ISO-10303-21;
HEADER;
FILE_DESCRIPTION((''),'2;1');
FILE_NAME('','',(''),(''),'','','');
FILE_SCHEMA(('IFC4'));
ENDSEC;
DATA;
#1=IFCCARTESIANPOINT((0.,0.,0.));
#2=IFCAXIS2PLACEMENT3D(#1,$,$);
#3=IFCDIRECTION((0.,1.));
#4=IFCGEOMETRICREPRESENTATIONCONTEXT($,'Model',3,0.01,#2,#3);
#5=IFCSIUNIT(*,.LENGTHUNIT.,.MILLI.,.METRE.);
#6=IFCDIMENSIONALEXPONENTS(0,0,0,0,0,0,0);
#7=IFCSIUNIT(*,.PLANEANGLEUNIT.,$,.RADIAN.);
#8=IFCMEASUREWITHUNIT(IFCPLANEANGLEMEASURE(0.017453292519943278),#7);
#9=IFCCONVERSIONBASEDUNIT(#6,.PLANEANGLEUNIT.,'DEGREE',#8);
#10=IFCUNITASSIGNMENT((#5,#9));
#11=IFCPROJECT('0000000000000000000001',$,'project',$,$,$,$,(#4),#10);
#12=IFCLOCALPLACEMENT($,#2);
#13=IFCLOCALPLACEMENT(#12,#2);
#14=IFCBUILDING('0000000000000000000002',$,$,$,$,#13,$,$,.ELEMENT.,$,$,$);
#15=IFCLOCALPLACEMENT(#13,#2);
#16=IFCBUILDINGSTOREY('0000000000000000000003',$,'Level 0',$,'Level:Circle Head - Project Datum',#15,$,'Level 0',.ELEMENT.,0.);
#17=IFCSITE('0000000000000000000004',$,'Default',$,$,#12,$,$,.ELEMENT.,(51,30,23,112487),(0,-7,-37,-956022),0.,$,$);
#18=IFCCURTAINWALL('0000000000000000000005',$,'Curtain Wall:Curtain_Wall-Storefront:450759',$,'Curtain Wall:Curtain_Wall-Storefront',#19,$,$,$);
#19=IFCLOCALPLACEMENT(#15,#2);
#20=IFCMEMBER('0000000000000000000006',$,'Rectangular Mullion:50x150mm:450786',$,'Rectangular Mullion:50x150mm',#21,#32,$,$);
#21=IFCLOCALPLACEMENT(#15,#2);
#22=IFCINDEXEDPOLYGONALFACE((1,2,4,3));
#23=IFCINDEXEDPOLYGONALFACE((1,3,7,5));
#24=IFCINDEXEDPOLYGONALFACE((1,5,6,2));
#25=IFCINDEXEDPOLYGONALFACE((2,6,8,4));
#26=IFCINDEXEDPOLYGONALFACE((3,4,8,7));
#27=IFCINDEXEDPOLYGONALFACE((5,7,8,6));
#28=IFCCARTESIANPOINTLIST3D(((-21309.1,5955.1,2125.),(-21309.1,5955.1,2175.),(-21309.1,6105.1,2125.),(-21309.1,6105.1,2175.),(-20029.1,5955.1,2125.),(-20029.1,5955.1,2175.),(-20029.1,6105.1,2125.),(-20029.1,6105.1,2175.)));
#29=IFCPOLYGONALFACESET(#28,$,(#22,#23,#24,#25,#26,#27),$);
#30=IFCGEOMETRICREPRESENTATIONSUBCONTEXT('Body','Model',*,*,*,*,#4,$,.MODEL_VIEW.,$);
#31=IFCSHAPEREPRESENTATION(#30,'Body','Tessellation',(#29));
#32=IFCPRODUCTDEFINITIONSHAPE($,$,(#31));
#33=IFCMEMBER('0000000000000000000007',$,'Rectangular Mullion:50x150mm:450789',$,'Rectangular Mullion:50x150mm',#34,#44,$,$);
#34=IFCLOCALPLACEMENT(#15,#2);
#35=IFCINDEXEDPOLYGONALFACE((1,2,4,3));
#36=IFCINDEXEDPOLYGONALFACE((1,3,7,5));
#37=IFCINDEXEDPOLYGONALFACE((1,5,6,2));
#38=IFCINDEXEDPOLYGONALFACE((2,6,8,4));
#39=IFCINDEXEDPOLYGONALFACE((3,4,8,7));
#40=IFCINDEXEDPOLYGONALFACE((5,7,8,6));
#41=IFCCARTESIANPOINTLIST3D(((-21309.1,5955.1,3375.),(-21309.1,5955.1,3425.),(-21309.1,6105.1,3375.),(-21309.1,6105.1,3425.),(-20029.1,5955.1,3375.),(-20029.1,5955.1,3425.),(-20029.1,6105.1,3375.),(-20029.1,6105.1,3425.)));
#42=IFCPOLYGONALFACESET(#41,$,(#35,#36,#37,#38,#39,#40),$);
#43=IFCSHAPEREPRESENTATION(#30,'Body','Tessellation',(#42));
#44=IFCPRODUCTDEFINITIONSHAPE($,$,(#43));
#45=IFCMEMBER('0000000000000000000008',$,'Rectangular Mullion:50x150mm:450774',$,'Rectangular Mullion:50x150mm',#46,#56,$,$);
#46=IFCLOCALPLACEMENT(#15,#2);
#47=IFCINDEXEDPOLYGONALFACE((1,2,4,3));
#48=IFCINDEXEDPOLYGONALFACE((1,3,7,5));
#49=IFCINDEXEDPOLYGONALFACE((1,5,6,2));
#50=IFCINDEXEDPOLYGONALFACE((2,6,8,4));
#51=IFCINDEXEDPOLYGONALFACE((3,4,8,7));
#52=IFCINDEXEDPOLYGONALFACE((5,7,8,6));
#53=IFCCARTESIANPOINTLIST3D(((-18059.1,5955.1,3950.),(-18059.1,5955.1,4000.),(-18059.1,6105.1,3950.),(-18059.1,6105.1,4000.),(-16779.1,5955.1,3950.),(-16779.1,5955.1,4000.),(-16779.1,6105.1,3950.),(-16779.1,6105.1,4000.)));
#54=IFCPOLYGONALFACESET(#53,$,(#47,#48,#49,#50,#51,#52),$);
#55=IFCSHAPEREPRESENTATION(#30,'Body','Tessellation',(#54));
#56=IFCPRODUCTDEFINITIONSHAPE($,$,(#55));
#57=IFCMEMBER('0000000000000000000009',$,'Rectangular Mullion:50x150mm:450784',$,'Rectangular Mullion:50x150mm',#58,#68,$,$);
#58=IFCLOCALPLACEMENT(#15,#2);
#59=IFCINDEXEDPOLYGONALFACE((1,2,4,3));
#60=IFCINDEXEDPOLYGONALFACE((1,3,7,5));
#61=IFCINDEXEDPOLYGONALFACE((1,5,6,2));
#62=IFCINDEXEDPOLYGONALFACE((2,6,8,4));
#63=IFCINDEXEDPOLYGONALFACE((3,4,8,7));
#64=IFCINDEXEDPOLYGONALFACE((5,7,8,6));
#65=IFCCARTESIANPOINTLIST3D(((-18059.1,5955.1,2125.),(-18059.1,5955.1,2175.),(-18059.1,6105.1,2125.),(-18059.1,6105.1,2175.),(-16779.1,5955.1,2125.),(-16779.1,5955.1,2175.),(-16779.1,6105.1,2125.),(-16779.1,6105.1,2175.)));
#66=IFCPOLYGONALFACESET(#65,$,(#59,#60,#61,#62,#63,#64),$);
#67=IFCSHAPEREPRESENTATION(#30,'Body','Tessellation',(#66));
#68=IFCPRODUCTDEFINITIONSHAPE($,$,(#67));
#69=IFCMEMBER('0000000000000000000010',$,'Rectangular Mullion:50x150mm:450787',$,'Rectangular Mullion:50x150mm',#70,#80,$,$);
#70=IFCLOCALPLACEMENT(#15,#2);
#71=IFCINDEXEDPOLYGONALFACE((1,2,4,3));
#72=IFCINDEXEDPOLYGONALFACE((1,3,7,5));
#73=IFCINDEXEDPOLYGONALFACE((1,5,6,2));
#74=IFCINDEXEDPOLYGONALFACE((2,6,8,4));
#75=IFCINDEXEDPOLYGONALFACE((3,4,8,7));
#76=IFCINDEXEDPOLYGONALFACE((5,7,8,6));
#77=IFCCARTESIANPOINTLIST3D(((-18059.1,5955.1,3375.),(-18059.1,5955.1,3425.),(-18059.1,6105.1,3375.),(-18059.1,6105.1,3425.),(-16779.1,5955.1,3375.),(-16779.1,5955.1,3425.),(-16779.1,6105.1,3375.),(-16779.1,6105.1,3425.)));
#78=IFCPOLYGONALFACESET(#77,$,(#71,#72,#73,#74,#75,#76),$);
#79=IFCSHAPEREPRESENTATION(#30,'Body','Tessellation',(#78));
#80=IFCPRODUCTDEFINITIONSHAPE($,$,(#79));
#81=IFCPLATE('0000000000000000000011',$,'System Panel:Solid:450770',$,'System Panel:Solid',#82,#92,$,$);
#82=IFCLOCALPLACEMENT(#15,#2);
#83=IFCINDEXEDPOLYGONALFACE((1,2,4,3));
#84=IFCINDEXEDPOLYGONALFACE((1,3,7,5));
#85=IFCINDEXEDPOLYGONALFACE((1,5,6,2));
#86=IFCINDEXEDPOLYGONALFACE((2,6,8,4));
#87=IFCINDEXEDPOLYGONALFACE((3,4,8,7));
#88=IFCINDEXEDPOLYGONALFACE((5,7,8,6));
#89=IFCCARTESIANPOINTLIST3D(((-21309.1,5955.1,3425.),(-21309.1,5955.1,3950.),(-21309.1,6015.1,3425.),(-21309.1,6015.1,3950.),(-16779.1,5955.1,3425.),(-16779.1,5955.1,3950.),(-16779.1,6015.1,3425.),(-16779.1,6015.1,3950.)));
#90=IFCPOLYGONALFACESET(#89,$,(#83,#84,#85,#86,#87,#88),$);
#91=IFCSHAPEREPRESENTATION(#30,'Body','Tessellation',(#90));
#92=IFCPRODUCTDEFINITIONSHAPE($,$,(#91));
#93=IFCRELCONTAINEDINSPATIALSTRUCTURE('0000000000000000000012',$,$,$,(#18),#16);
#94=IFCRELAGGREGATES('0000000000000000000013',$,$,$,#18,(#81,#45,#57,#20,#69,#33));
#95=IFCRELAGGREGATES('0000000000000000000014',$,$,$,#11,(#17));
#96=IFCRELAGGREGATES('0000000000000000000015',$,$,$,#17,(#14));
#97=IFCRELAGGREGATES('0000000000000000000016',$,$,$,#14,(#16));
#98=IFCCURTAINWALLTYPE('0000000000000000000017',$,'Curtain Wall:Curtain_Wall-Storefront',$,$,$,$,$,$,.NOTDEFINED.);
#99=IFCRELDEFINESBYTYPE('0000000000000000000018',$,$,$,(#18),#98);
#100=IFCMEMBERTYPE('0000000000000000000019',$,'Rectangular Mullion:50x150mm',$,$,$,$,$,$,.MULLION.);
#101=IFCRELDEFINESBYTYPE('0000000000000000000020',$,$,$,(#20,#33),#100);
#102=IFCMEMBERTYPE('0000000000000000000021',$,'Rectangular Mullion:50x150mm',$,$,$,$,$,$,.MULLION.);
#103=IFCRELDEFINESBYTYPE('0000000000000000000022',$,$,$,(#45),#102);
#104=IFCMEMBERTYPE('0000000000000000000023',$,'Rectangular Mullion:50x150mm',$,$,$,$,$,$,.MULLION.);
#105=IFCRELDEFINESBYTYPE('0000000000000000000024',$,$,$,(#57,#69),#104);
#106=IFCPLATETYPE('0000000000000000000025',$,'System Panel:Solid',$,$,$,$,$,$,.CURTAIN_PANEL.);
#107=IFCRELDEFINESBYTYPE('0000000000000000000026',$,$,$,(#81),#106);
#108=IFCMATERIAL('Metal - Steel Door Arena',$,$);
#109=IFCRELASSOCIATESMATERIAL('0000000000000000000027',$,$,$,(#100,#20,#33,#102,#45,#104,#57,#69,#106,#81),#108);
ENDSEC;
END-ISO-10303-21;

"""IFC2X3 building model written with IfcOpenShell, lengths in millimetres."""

from ifc_helpers import new_model, entity, si_unit, converted_unit, direction, frame, frame_2d, origin, origin_2d_with_axis, place, context, subcontext, project, spatial, rectangle, extrude, source, transform, mapped, material, type_object, type_shapes, element, aggregate, save


model = new_model("IFC2X3")

# Units and contexts
model_context = context("Model", 3, precision=0.01, world=origin(), true_north=direction((0.0, 1.0)))
body_context = subcontext(model_context, "Body", "Model", "MODEL_VIEW")
ifc_project = project(units=[si_unit("LENGTHUNIT", "METRE", prefix="MILLI"), converted_unit("PLANEANGLEUNIT", "DEGREE", entity("IfcPlaneAngleMeasure", 0.017453292519943278), si_unit("PLANEANGLEUNIT", "RADIAN"), dimensions=[0, 0, 0, 0, 0, 0, 0])], contexts=[model_context])

# Site, building, storey
site_placement = place(None, origin())
site = spatial("IfcSite", under=ifc_project, at=site_placement, Name="Default", CompositionType="ELEMENT", RefLatitude=(51, 30, 23, 112487), RefLongitude=(0, -7, -37, -956022), RefElevation=0.0)
building_placement = place(site_placement, origin())
building = spatial("IfcBuilding", under=site, at=building_placement, CompositionType="ELEMENT")
storey_placement = place(building_placement, origin())
storey = spatial("IfcBuildingStorey", under=building, at=storey_placement, Name="Level 0", ObjectType="Level:Circle Head - Project Datum", LongName="Level 0", CompositionType="ELEMENT", Elevation=0.0)

# Curtain wall, members, plate
curtain_wall_type = type_object("IfcCurtainWallType", Name="Curtain Wall:Curtain_Wall-Storefront", PredefinedType="NOTDEFINED")
curtain_wall_placement = place(storey_placement, origin())
curtain_wall = element("IfcCurtainWall", 1, at=curtain_wall_placement, inside=storey, type_object=curtain_wall_type, Name="Curtain Wall:Curtain_Wall-Storefront:450759", ObjectType="Curtain Wall:Curtain_Wall-Storefront")
ifc_material_1 = material(Name="Metal - Steel Door Arena")
member_type_1 = type_object("IfcMemberType", Name="Rectangular Mullion:50x150mm", PredefinedType="MULLION", material=ifc_material_1)
shared_shape_1 = source(origin(), body_context, "Body", "SweptSolid", [
    extrude(rectangle(XDim=50.0, YDim=150.0, at=origin_2d_with_axis()), frame((0.0, 0.0, -1280.0), z_axis=(0.0, 0.0, 1.0), x_axis=(-1.0, 0.0, 0.0)), (0.0, 0.0, 1.0), 1280.0),
])
type_shapes(member_type_1, [shared_shape_1])
member_1_placement = place(curtain_wall_placement, frame((-21309.1, 6030.1, 2150.0), z_axis=(-1.0, 0.0, 0.0), x_axis=(0.0, 0.0, 1.0)))
member_1 = element("IfcMember", 2, at=member_1_placement, type_object=member_type_1, material=ifc_material_1, Name="Rectangular Mullion:50x150mm:450786", ObjectType="Rectangular Mullion:50x150mm", context=body_context, shape_type="MappedRepresentation", body=[
    mapped(shared_shape_1, transform((0.0, 0.0, 0.0), scale=1.0)),
])
member_2_placement = place(curtain_wall_placement, frame((-21309.1, 6030.1, 3400.0), z_axis=(-1.0, 0.0, 0.0), x_axis=(0.0, 0.0, 1.0)))
member_2 = element("IfcMember", 3, at=member_2_placement, type_object=member_type_1, material=ifc_material_1, Name="Rectangular Mullion:50x150mm:450789", ObjectType="Rectangular Mullion:50x150mm", context=body_context, shape_type="MappedRepresentation", body=[
    mapped(shared_shape_1, transform((0.0, 0.0, 0.0), scale=1.0)),
])
member_type_2 = type_object("IfcMemberType", Name="Rectangular Mullion:50x150mm", PredefinedType="MULLION", material=ifc_material_1)
shared_shape_2 = source(origin(), body_context, "Body", "SweptSolid", [
    extrude(rectangle(XDim=50.0, YDim=150.0, at=origin_2d_with_axis()), frame((-25.0, 0.0, -1280.0), z_axis=(0.0, 0.0, 1.0), x_axis=(-1.0, 0.0, 0.0)), (0.0, 0.0, 1.0), 1280.0),
])
type_shapes(member_type_2, [shared_shape_2])
member_3_placement = place(curtain_wall_placement, frame((-18059.1, 6030.1, 4000.0), z_axis=(-1.0, 0.0, 0.0), x_axis=(0.0, 0.0, 1.0)))
member_3 = element("IfcMember", 4, at=member_3_placement, type_object=member_type_2, material=ifc_material_1, Name="Rectangular Mullion:50x150mm:450774", ObjectType="Rectangular Mullion:50x150mm", context=body_context, shape_type="MappedRepresentation", body=[
    mapped(shared_shape_2, transform((0.0, 0.0, 0.0), scale=1.0)),
])
member_type_3 = type_object("IfcMemberType", Name="Rectangular Mullion:50x150mm", PredefinedType="MULLION", material=ifc_material_1)
shared_shape_3 = source(origin(), body_context, "Body", "SweptSolid", [
    extrude(rectangle(XDim=50.0, YDim=150.0, at=origin_2d_with_axis()), frame((0.0, 0.0, -1280.0), z_axis=(0.0, 0.0, 1.0), x_axis=(-1.0, 0.0, 0.0)), (0.0, 0.0, 1.0), 1280.0),
])
type_shapes(member_type_3, [shared_shape_3])
member_4_placement = place(curtain_wall_placement, frame((-18059.1, 6030.1, 2150.0), z_axis=(-1.0, 0.0, 0.0), x_axis=(0.0, 0.0, 1.0)))
member_4 = element("IfcMember", 5, at=member_4_placement, type_object=member_type_3, material=ifc_material_1, Name="Rectangular Mullion:50x150mm:450784", ObjectType="Rectangular Mullion:50x150mm", context=body_context, shape_type="MappedRepresentation", body=[
    mapped(shared_shape_3, transform((0.0, 0.0, 0.0), scale=1.0)),
])
member_5_placement = place(curtain_wall_placement, frame((-18059.1, 6030.1, 3400.0), z_axis=(-1.0, 0.0, 0.0), x_axis=(0.0, 0.0, 1.0)))
member_5 = element("IfcMember", 6, at=member_5_placement, type_object=member_type_3, material=ifc_material_1, Name="Rectangular Mullion:50x150mm:450787", ObjectType="Rectangular Mullion:50x150mm", context=body_context, shape_type="MappedRepresentation", body=[
    mapped(shared_shape_3, transform((0.0, 0.0, 0.0), scale=1.0)),
])
plate_type_1 = type_object("IfcPlateType", Name="System Panel:Solid", PredefinedType="CURTAIN_PANEL", material=ifc_material_1)
shared_shape_4 = source(origin(), body_context, "Body", "SweptSolid", [
    extrude(rectangle(XDim=525.0, YDim=4530.0, at=frame_2d((0.0, 0.0), x_axis=(1.0, 0.0))), frame((0.0, 15.0, 262.5), z_axis=(0.0, 1.0, 0.0), x_axis=(0.0, 0.0, 1.0)), (0.0, 0.0, 1.0), 60.0),
])
type_shapes(plate_type_1, [shared_shape_4])
plate_1_placement = place(curtain_wall_placement, frame((-19044.1, 6030.1, 3425.0), z_axis=(0.0, 0.0, 1.0), x_axis=(-1.0, 0.0, 0.0)))
plate_1 = element("IfcPlate", 7, at=plate_1_placement, type_object=plate_type_1, material=ifc_material_1, Name="System Panel:Solid:450770", ObjectType="System Panel:Solid", context=body_context, shape_type="MappedRepresentation", body=[
    mapped(shared_shape_4, transform((0.0, 0.0, 0.0), scale=1.0)),
])
aggregate(curtain_wall, [plate_1, member_3, member_4, member_1, member_5, member_2])

save(model, "model.ifc")
